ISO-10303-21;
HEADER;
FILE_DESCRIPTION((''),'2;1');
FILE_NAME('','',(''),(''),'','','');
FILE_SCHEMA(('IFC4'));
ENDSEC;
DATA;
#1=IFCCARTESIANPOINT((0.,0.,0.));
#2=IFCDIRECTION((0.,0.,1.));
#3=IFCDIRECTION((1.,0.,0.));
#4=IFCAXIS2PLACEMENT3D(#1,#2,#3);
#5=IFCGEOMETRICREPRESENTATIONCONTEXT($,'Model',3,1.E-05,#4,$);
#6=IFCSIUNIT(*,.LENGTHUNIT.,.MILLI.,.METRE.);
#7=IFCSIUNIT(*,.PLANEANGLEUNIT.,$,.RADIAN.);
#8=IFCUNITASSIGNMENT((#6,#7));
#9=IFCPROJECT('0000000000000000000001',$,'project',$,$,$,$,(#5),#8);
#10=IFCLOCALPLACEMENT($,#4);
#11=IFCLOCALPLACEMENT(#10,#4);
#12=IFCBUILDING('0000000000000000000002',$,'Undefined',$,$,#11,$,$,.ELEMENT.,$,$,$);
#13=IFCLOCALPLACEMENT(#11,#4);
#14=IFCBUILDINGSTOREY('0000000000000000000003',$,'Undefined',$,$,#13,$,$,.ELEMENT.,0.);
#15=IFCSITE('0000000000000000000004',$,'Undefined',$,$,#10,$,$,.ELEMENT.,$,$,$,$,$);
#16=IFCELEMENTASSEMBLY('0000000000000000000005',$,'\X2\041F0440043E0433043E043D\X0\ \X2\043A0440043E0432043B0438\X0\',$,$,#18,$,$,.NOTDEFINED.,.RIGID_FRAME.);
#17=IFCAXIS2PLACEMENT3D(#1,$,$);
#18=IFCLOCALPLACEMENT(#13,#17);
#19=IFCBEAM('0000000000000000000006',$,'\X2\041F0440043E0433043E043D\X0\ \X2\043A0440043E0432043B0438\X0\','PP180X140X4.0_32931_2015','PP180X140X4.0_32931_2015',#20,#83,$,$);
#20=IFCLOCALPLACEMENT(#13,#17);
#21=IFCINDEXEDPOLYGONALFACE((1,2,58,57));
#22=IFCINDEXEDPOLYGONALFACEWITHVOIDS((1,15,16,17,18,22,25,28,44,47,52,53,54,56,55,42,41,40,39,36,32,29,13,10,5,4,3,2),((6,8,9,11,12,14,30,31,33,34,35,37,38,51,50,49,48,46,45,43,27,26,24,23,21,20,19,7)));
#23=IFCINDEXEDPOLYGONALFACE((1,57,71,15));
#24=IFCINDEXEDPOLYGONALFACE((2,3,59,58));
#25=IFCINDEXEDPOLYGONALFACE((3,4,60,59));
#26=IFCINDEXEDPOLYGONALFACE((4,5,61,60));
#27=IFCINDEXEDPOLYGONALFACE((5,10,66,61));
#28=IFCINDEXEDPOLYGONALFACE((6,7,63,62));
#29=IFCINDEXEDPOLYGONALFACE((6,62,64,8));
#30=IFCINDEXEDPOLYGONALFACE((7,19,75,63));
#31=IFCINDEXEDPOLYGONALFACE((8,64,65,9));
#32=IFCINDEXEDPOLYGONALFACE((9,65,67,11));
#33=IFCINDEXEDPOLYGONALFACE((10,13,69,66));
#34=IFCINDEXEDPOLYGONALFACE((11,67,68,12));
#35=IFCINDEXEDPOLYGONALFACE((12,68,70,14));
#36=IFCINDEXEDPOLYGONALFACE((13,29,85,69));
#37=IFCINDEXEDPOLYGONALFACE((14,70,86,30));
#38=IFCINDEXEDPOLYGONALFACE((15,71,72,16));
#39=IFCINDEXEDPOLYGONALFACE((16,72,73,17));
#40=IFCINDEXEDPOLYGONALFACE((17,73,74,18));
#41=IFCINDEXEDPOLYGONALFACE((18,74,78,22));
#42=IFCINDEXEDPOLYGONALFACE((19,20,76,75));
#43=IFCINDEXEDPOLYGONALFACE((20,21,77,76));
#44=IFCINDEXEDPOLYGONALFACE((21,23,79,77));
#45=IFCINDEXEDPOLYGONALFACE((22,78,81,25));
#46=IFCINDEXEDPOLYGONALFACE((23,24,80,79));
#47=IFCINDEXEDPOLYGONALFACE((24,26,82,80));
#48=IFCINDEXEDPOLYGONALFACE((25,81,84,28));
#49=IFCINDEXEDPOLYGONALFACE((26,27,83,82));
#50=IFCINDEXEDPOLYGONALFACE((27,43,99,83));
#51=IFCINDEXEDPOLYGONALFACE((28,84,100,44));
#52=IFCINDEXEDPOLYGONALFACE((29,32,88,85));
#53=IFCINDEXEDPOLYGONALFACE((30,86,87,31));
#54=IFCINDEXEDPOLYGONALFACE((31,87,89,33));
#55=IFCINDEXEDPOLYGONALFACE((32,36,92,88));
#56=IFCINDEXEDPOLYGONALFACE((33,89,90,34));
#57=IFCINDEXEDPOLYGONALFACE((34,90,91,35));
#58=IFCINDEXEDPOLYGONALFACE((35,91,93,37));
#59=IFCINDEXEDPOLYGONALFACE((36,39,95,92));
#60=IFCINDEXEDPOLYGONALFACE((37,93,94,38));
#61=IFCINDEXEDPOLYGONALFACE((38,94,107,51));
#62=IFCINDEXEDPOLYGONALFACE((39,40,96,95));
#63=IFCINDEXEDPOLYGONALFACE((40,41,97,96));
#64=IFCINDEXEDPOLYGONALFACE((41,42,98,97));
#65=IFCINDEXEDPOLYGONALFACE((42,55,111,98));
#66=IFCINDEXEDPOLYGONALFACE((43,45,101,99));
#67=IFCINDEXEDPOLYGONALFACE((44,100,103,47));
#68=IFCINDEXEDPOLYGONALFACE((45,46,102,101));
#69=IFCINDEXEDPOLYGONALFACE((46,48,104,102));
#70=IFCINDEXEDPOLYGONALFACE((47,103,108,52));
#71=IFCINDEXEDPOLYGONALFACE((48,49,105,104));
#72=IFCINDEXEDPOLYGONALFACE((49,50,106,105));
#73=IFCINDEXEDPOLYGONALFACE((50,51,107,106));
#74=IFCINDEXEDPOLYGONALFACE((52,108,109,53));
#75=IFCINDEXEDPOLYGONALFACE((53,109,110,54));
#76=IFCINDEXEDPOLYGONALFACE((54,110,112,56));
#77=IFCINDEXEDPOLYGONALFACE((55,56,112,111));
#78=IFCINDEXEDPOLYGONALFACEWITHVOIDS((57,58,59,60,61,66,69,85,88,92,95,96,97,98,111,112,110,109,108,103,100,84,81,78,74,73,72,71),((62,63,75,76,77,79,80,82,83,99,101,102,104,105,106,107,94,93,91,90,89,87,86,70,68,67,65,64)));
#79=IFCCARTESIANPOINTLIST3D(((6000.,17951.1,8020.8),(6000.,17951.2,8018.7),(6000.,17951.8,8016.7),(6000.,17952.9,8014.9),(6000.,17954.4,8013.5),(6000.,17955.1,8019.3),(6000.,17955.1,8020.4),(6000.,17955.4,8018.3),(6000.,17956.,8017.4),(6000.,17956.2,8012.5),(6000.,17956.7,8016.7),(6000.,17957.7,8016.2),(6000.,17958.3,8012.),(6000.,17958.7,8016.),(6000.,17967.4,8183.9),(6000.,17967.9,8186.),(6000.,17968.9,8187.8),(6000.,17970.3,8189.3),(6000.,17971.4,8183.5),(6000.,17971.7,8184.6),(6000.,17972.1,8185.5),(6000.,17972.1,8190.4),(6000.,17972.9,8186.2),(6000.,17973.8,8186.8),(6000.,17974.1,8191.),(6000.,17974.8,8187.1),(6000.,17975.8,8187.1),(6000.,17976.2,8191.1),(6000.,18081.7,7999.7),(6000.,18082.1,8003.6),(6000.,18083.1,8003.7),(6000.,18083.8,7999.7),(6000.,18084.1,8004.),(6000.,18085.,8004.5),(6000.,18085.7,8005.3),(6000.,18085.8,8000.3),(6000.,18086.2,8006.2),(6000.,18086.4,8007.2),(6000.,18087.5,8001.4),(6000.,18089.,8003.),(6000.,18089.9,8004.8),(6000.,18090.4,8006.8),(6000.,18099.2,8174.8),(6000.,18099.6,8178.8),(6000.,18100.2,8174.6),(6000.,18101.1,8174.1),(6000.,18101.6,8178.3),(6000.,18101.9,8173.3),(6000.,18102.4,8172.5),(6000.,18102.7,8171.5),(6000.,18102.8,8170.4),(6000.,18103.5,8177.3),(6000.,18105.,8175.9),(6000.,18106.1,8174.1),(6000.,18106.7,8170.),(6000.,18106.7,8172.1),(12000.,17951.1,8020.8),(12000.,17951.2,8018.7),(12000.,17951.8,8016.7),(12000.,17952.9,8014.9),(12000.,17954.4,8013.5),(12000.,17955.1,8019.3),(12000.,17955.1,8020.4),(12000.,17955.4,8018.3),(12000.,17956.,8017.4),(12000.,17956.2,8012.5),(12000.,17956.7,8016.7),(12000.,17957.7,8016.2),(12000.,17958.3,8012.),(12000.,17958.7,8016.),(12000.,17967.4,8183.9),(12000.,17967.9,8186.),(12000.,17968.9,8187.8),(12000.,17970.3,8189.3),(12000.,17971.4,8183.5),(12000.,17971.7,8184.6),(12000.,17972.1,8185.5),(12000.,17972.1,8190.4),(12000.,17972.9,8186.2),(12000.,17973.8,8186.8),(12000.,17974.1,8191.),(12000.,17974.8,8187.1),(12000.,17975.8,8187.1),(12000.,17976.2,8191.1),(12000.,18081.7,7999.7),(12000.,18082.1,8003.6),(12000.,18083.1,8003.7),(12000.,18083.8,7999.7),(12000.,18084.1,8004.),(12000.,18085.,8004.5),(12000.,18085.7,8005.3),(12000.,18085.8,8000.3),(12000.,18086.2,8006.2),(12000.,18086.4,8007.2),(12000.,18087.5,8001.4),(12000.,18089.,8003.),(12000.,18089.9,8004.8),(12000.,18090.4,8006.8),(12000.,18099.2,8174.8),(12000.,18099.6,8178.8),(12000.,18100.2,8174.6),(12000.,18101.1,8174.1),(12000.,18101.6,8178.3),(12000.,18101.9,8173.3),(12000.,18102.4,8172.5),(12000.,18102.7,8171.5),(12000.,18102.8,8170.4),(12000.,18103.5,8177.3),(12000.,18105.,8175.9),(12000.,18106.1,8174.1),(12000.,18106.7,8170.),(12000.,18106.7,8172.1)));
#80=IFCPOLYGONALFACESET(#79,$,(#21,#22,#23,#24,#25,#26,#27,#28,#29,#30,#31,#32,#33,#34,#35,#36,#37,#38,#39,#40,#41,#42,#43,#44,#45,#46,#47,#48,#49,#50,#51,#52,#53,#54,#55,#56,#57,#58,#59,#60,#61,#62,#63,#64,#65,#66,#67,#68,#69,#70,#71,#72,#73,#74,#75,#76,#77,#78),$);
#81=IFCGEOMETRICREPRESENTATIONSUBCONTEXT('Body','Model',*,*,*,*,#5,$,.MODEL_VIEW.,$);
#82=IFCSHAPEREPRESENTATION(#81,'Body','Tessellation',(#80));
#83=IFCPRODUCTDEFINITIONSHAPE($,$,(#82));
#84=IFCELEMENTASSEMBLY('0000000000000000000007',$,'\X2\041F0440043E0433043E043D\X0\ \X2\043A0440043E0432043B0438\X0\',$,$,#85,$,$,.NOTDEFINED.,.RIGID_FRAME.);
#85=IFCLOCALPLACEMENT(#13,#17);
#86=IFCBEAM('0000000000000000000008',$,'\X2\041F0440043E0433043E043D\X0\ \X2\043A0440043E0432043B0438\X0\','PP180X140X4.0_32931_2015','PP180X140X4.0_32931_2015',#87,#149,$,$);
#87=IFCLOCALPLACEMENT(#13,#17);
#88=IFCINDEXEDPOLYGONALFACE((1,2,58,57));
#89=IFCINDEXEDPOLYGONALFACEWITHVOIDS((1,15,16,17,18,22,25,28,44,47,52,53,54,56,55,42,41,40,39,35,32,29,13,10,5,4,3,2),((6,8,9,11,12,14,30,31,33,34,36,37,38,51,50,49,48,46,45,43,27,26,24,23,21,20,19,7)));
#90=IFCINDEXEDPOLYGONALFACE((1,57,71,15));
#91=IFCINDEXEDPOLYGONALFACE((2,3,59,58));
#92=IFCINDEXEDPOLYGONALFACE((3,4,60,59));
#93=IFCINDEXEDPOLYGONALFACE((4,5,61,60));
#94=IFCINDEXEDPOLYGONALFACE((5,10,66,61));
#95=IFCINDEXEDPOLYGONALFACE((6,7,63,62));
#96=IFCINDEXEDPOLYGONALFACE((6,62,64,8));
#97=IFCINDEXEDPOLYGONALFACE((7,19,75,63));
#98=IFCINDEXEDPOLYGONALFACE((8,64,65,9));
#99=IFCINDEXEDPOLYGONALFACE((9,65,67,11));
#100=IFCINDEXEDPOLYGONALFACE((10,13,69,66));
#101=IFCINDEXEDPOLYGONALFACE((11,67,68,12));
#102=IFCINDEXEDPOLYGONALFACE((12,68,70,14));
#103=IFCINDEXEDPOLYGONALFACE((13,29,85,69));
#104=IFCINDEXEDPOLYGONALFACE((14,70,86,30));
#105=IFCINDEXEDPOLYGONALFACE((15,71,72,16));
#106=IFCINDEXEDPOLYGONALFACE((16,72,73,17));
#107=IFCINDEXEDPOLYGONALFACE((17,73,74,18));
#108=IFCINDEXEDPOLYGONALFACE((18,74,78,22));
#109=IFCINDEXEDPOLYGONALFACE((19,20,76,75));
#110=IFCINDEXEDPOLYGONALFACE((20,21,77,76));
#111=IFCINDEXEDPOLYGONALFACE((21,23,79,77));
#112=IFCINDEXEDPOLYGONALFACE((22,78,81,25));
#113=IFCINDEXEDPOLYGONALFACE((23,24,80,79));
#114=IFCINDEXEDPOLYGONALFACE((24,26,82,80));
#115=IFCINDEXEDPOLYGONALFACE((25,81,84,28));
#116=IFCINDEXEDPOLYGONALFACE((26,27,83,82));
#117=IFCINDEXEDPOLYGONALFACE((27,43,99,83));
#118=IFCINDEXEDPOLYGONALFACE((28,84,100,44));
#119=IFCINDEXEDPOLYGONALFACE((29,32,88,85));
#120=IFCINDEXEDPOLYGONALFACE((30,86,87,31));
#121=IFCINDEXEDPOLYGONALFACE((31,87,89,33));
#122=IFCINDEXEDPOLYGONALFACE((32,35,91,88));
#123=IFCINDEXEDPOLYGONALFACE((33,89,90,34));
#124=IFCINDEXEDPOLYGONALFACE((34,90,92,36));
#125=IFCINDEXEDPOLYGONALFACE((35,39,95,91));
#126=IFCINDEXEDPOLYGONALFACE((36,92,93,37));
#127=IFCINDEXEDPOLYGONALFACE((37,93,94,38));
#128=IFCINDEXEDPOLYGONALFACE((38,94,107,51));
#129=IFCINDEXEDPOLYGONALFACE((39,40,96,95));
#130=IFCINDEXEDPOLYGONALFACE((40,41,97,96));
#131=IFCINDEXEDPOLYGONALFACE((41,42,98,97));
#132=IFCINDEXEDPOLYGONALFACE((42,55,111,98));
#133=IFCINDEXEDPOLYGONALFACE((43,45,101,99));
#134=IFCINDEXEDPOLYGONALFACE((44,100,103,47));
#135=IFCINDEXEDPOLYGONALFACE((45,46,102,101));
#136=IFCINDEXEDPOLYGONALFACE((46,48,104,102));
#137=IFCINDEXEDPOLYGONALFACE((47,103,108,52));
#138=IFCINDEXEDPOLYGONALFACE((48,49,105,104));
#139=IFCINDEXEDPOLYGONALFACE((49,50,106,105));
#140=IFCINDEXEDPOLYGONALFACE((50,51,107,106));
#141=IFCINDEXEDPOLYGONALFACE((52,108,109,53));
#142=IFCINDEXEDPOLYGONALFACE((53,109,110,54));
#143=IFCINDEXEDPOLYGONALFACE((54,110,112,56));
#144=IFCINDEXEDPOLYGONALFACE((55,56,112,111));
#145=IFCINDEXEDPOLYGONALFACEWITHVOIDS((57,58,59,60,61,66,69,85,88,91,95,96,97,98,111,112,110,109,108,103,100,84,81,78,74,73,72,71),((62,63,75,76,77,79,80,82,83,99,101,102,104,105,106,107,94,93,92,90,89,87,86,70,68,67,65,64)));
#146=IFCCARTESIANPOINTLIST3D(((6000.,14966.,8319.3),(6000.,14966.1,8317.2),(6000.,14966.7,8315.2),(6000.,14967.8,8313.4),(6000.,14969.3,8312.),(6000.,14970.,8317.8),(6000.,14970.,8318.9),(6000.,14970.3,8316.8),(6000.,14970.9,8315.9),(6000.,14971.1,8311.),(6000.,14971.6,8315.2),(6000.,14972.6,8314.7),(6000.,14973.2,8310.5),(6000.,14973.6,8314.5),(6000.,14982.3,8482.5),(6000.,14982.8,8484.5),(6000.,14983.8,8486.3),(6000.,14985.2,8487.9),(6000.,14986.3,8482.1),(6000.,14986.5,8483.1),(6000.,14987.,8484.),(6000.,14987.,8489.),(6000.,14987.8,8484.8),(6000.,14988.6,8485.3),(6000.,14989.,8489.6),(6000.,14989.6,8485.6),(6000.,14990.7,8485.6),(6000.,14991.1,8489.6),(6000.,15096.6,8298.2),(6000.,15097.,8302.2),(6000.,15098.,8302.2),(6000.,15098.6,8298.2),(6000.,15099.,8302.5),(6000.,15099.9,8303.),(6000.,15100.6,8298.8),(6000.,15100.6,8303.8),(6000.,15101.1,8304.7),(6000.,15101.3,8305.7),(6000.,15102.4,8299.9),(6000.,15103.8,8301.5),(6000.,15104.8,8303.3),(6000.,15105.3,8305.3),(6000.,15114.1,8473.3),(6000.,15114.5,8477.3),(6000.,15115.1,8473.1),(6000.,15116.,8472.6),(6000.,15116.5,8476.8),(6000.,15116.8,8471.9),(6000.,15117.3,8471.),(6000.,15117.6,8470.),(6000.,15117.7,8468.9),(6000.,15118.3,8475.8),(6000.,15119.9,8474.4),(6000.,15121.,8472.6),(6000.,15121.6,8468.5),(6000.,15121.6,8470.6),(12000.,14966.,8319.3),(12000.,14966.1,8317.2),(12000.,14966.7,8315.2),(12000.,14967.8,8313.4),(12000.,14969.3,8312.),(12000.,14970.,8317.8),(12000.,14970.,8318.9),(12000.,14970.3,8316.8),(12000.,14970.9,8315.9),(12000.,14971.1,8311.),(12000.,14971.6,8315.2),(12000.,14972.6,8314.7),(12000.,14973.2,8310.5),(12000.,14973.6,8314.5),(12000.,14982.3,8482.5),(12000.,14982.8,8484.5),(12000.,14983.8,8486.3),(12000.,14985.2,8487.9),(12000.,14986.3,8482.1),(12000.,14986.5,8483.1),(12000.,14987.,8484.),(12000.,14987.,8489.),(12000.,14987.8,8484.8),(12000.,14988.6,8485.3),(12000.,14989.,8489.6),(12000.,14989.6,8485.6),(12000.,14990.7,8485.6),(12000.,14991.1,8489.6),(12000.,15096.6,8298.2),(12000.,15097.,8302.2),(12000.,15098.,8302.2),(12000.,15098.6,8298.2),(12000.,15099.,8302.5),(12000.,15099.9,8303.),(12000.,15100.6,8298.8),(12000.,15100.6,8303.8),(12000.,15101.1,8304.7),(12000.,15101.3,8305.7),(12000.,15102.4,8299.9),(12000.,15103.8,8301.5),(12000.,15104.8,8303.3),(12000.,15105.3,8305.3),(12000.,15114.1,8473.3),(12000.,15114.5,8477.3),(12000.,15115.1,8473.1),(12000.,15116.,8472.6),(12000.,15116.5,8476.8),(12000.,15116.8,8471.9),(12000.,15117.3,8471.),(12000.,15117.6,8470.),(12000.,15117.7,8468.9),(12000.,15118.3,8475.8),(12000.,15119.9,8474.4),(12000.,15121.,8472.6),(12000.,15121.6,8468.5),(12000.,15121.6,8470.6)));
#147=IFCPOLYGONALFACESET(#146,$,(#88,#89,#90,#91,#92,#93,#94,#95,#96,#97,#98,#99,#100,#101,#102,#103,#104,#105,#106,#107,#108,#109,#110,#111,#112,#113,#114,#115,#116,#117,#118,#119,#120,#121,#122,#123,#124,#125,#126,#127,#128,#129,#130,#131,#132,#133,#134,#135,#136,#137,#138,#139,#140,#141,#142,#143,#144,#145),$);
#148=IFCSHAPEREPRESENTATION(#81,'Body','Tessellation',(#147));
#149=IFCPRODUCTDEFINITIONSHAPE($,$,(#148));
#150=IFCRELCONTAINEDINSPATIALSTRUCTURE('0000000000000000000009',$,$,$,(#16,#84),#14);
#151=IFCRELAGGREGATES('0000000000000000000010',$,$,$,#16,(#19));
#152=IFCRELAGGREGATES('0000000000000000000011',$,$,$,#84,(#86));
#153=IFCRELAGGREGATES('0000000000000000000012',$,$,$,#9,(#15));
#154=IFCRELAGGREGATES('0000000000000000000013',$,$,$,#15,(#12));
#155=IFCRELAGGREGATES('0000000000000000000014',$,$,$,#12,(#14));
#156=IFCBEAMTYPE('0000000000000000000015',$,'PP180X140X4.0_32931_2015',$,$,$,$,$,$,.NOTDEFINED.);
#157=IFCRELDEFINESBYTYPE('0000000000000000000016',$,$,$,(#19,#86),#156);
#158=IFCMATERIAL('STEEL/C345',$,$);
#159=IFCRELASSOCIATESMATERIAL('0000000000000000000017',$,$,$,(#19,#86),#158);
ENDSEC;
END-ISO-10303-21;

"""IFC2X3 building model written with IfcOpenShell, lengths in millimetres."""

from ifc_helpers import new_model, si_unit, frame, origin_with_axes, origin_2d_with_axis, place, context, subcontext, project, spatial, hollow_rectangle, extrude, material, type_object, element, aggregate, save


model = new_model("IFC2X3")

# Units and contexts
model_context = context("Model", 3, precision=1e-05, world=origin_with_axes())
body_context = subcontext(model_context, "Body", "Model", "MODEL_VIEW")
ifc_project = project(units=[si_unit("LENGTHUNIT", "METRE", prefix="MILLI"), si_unit("PLANEANGLEUNIT", "RADIAN")], contexts=[model_context])

# Site, building, storey
site_placement = place(None, origin_with_axes())
site = spatial("IfcSite", under=ifc_project, at=site_placement, Name="Undefined", CompositionType="ELEMENT")
building_placement = place(site_placement, origin_with_axes())
building = spatial("IfcBuilding", under=site, at=building_placement, Name="Undefined", CompositionType="ELEMENT")
storey_placement = place(building_placement, origin_with_axes())
storey = spatial("IfcBuildingStorey", under=building, at=storey_placement, Name="Undefined", CompositionType="ELEMENT", Elevation=0.0)

# Shared definitions
ifc_material_1 = material(Name="STEEL/C345")

# Element assemblies, beams
beam_type_1 = type_object("IfcBeamType", Name="PP180X140X4.0_32931_2015", PredefinedType="NOTDEFINED")
assembly_1_placement = place(storey_placement, origin_with_axes())
assembly_1 = element("IfcElementAssembly", 1, at=assembly_1_placement, inside=storey, Name="Прогон кровли", AssemblyPlace="NOTDEFINED", PredefinedType="RIGID_FRAME")
beam_1_placement = place(assembly_1_placement, frame((6000.0, 18028.9, 8095.4), z_axis=(0.0, 0.099504, 0.995037), x_axis=(1.0, 0.0, 0.0)))
beam_1 = element("IfcBeam", 2, at=beam_1_placement, type_object=beam_type_1, material=ifc_material_1, Name="Прогон кровли", Description="PP180X140X4.0_32931_2015", ObjectType="PP180X140X4.0_32931_2015", context=body_context, shape_type="SweptSolid", body=[
    extrude(hollow_rectangle(XDim=140.0, YDim=180.0, WallThickness=4.0, InnerFilletRadius=4.0, OuterFilletRadius=8.0, at=origin_2d_with_axis()), frame((6000.0, 0.0, 0.0), z_axis=(-1.0, 0.0, 0.0), x_axis=(0.0, -1.0, 0.0)), (0.0, 0.0, 1.0), 6000.0),
])
aggregate(assembly_1, [beam_1])
assembly_2_placement = place(storey_placement, origin_with_axes())
assembly_2 = element("IfcElementAssembly", 3, at=assembly_2_placement, inside=storey, Name="Прогон кровли", AssemblyPlace="NOTDEFINED", PredefinedType="RIGID_FRAME")
beam_2_placement = place(assembly_2_placement, frame((6000.0, 15043.8, 8393.9), z_axis=(0.0, 0.099504, 0.995037), x_axis=(1.0, 0.0, 0.0)))
beam_2 = element("IfcBeam", 4, at=beam_2_placement, type_object=beam_type_1, material=ifc_material_1, Name="Прогон кровли", Description="PP180X140X4.0_32931_2015", ObjectType="PP180X140X4.0_32931_2015", context=body_context, shape_type="SweptSolid", body=[
    extrude(hollow_rectangle(XDim=140.0, YDim=180.0, WallThickness=4.0, InnerFilletRadius=4.0, OuterFilletRadius=8.0, at=origin_2d_with_axis()), frame((6000.0, 0.0, 0.0), z_axis=(-1.0, 0.0, 0.0), x_axis=(0.0, -1.0, 0.0)), (0.0, 0.0, 1.0), 6000.0),
])
aggregate(assembly_2, [beam_2])

save(model, "model.ifc")
